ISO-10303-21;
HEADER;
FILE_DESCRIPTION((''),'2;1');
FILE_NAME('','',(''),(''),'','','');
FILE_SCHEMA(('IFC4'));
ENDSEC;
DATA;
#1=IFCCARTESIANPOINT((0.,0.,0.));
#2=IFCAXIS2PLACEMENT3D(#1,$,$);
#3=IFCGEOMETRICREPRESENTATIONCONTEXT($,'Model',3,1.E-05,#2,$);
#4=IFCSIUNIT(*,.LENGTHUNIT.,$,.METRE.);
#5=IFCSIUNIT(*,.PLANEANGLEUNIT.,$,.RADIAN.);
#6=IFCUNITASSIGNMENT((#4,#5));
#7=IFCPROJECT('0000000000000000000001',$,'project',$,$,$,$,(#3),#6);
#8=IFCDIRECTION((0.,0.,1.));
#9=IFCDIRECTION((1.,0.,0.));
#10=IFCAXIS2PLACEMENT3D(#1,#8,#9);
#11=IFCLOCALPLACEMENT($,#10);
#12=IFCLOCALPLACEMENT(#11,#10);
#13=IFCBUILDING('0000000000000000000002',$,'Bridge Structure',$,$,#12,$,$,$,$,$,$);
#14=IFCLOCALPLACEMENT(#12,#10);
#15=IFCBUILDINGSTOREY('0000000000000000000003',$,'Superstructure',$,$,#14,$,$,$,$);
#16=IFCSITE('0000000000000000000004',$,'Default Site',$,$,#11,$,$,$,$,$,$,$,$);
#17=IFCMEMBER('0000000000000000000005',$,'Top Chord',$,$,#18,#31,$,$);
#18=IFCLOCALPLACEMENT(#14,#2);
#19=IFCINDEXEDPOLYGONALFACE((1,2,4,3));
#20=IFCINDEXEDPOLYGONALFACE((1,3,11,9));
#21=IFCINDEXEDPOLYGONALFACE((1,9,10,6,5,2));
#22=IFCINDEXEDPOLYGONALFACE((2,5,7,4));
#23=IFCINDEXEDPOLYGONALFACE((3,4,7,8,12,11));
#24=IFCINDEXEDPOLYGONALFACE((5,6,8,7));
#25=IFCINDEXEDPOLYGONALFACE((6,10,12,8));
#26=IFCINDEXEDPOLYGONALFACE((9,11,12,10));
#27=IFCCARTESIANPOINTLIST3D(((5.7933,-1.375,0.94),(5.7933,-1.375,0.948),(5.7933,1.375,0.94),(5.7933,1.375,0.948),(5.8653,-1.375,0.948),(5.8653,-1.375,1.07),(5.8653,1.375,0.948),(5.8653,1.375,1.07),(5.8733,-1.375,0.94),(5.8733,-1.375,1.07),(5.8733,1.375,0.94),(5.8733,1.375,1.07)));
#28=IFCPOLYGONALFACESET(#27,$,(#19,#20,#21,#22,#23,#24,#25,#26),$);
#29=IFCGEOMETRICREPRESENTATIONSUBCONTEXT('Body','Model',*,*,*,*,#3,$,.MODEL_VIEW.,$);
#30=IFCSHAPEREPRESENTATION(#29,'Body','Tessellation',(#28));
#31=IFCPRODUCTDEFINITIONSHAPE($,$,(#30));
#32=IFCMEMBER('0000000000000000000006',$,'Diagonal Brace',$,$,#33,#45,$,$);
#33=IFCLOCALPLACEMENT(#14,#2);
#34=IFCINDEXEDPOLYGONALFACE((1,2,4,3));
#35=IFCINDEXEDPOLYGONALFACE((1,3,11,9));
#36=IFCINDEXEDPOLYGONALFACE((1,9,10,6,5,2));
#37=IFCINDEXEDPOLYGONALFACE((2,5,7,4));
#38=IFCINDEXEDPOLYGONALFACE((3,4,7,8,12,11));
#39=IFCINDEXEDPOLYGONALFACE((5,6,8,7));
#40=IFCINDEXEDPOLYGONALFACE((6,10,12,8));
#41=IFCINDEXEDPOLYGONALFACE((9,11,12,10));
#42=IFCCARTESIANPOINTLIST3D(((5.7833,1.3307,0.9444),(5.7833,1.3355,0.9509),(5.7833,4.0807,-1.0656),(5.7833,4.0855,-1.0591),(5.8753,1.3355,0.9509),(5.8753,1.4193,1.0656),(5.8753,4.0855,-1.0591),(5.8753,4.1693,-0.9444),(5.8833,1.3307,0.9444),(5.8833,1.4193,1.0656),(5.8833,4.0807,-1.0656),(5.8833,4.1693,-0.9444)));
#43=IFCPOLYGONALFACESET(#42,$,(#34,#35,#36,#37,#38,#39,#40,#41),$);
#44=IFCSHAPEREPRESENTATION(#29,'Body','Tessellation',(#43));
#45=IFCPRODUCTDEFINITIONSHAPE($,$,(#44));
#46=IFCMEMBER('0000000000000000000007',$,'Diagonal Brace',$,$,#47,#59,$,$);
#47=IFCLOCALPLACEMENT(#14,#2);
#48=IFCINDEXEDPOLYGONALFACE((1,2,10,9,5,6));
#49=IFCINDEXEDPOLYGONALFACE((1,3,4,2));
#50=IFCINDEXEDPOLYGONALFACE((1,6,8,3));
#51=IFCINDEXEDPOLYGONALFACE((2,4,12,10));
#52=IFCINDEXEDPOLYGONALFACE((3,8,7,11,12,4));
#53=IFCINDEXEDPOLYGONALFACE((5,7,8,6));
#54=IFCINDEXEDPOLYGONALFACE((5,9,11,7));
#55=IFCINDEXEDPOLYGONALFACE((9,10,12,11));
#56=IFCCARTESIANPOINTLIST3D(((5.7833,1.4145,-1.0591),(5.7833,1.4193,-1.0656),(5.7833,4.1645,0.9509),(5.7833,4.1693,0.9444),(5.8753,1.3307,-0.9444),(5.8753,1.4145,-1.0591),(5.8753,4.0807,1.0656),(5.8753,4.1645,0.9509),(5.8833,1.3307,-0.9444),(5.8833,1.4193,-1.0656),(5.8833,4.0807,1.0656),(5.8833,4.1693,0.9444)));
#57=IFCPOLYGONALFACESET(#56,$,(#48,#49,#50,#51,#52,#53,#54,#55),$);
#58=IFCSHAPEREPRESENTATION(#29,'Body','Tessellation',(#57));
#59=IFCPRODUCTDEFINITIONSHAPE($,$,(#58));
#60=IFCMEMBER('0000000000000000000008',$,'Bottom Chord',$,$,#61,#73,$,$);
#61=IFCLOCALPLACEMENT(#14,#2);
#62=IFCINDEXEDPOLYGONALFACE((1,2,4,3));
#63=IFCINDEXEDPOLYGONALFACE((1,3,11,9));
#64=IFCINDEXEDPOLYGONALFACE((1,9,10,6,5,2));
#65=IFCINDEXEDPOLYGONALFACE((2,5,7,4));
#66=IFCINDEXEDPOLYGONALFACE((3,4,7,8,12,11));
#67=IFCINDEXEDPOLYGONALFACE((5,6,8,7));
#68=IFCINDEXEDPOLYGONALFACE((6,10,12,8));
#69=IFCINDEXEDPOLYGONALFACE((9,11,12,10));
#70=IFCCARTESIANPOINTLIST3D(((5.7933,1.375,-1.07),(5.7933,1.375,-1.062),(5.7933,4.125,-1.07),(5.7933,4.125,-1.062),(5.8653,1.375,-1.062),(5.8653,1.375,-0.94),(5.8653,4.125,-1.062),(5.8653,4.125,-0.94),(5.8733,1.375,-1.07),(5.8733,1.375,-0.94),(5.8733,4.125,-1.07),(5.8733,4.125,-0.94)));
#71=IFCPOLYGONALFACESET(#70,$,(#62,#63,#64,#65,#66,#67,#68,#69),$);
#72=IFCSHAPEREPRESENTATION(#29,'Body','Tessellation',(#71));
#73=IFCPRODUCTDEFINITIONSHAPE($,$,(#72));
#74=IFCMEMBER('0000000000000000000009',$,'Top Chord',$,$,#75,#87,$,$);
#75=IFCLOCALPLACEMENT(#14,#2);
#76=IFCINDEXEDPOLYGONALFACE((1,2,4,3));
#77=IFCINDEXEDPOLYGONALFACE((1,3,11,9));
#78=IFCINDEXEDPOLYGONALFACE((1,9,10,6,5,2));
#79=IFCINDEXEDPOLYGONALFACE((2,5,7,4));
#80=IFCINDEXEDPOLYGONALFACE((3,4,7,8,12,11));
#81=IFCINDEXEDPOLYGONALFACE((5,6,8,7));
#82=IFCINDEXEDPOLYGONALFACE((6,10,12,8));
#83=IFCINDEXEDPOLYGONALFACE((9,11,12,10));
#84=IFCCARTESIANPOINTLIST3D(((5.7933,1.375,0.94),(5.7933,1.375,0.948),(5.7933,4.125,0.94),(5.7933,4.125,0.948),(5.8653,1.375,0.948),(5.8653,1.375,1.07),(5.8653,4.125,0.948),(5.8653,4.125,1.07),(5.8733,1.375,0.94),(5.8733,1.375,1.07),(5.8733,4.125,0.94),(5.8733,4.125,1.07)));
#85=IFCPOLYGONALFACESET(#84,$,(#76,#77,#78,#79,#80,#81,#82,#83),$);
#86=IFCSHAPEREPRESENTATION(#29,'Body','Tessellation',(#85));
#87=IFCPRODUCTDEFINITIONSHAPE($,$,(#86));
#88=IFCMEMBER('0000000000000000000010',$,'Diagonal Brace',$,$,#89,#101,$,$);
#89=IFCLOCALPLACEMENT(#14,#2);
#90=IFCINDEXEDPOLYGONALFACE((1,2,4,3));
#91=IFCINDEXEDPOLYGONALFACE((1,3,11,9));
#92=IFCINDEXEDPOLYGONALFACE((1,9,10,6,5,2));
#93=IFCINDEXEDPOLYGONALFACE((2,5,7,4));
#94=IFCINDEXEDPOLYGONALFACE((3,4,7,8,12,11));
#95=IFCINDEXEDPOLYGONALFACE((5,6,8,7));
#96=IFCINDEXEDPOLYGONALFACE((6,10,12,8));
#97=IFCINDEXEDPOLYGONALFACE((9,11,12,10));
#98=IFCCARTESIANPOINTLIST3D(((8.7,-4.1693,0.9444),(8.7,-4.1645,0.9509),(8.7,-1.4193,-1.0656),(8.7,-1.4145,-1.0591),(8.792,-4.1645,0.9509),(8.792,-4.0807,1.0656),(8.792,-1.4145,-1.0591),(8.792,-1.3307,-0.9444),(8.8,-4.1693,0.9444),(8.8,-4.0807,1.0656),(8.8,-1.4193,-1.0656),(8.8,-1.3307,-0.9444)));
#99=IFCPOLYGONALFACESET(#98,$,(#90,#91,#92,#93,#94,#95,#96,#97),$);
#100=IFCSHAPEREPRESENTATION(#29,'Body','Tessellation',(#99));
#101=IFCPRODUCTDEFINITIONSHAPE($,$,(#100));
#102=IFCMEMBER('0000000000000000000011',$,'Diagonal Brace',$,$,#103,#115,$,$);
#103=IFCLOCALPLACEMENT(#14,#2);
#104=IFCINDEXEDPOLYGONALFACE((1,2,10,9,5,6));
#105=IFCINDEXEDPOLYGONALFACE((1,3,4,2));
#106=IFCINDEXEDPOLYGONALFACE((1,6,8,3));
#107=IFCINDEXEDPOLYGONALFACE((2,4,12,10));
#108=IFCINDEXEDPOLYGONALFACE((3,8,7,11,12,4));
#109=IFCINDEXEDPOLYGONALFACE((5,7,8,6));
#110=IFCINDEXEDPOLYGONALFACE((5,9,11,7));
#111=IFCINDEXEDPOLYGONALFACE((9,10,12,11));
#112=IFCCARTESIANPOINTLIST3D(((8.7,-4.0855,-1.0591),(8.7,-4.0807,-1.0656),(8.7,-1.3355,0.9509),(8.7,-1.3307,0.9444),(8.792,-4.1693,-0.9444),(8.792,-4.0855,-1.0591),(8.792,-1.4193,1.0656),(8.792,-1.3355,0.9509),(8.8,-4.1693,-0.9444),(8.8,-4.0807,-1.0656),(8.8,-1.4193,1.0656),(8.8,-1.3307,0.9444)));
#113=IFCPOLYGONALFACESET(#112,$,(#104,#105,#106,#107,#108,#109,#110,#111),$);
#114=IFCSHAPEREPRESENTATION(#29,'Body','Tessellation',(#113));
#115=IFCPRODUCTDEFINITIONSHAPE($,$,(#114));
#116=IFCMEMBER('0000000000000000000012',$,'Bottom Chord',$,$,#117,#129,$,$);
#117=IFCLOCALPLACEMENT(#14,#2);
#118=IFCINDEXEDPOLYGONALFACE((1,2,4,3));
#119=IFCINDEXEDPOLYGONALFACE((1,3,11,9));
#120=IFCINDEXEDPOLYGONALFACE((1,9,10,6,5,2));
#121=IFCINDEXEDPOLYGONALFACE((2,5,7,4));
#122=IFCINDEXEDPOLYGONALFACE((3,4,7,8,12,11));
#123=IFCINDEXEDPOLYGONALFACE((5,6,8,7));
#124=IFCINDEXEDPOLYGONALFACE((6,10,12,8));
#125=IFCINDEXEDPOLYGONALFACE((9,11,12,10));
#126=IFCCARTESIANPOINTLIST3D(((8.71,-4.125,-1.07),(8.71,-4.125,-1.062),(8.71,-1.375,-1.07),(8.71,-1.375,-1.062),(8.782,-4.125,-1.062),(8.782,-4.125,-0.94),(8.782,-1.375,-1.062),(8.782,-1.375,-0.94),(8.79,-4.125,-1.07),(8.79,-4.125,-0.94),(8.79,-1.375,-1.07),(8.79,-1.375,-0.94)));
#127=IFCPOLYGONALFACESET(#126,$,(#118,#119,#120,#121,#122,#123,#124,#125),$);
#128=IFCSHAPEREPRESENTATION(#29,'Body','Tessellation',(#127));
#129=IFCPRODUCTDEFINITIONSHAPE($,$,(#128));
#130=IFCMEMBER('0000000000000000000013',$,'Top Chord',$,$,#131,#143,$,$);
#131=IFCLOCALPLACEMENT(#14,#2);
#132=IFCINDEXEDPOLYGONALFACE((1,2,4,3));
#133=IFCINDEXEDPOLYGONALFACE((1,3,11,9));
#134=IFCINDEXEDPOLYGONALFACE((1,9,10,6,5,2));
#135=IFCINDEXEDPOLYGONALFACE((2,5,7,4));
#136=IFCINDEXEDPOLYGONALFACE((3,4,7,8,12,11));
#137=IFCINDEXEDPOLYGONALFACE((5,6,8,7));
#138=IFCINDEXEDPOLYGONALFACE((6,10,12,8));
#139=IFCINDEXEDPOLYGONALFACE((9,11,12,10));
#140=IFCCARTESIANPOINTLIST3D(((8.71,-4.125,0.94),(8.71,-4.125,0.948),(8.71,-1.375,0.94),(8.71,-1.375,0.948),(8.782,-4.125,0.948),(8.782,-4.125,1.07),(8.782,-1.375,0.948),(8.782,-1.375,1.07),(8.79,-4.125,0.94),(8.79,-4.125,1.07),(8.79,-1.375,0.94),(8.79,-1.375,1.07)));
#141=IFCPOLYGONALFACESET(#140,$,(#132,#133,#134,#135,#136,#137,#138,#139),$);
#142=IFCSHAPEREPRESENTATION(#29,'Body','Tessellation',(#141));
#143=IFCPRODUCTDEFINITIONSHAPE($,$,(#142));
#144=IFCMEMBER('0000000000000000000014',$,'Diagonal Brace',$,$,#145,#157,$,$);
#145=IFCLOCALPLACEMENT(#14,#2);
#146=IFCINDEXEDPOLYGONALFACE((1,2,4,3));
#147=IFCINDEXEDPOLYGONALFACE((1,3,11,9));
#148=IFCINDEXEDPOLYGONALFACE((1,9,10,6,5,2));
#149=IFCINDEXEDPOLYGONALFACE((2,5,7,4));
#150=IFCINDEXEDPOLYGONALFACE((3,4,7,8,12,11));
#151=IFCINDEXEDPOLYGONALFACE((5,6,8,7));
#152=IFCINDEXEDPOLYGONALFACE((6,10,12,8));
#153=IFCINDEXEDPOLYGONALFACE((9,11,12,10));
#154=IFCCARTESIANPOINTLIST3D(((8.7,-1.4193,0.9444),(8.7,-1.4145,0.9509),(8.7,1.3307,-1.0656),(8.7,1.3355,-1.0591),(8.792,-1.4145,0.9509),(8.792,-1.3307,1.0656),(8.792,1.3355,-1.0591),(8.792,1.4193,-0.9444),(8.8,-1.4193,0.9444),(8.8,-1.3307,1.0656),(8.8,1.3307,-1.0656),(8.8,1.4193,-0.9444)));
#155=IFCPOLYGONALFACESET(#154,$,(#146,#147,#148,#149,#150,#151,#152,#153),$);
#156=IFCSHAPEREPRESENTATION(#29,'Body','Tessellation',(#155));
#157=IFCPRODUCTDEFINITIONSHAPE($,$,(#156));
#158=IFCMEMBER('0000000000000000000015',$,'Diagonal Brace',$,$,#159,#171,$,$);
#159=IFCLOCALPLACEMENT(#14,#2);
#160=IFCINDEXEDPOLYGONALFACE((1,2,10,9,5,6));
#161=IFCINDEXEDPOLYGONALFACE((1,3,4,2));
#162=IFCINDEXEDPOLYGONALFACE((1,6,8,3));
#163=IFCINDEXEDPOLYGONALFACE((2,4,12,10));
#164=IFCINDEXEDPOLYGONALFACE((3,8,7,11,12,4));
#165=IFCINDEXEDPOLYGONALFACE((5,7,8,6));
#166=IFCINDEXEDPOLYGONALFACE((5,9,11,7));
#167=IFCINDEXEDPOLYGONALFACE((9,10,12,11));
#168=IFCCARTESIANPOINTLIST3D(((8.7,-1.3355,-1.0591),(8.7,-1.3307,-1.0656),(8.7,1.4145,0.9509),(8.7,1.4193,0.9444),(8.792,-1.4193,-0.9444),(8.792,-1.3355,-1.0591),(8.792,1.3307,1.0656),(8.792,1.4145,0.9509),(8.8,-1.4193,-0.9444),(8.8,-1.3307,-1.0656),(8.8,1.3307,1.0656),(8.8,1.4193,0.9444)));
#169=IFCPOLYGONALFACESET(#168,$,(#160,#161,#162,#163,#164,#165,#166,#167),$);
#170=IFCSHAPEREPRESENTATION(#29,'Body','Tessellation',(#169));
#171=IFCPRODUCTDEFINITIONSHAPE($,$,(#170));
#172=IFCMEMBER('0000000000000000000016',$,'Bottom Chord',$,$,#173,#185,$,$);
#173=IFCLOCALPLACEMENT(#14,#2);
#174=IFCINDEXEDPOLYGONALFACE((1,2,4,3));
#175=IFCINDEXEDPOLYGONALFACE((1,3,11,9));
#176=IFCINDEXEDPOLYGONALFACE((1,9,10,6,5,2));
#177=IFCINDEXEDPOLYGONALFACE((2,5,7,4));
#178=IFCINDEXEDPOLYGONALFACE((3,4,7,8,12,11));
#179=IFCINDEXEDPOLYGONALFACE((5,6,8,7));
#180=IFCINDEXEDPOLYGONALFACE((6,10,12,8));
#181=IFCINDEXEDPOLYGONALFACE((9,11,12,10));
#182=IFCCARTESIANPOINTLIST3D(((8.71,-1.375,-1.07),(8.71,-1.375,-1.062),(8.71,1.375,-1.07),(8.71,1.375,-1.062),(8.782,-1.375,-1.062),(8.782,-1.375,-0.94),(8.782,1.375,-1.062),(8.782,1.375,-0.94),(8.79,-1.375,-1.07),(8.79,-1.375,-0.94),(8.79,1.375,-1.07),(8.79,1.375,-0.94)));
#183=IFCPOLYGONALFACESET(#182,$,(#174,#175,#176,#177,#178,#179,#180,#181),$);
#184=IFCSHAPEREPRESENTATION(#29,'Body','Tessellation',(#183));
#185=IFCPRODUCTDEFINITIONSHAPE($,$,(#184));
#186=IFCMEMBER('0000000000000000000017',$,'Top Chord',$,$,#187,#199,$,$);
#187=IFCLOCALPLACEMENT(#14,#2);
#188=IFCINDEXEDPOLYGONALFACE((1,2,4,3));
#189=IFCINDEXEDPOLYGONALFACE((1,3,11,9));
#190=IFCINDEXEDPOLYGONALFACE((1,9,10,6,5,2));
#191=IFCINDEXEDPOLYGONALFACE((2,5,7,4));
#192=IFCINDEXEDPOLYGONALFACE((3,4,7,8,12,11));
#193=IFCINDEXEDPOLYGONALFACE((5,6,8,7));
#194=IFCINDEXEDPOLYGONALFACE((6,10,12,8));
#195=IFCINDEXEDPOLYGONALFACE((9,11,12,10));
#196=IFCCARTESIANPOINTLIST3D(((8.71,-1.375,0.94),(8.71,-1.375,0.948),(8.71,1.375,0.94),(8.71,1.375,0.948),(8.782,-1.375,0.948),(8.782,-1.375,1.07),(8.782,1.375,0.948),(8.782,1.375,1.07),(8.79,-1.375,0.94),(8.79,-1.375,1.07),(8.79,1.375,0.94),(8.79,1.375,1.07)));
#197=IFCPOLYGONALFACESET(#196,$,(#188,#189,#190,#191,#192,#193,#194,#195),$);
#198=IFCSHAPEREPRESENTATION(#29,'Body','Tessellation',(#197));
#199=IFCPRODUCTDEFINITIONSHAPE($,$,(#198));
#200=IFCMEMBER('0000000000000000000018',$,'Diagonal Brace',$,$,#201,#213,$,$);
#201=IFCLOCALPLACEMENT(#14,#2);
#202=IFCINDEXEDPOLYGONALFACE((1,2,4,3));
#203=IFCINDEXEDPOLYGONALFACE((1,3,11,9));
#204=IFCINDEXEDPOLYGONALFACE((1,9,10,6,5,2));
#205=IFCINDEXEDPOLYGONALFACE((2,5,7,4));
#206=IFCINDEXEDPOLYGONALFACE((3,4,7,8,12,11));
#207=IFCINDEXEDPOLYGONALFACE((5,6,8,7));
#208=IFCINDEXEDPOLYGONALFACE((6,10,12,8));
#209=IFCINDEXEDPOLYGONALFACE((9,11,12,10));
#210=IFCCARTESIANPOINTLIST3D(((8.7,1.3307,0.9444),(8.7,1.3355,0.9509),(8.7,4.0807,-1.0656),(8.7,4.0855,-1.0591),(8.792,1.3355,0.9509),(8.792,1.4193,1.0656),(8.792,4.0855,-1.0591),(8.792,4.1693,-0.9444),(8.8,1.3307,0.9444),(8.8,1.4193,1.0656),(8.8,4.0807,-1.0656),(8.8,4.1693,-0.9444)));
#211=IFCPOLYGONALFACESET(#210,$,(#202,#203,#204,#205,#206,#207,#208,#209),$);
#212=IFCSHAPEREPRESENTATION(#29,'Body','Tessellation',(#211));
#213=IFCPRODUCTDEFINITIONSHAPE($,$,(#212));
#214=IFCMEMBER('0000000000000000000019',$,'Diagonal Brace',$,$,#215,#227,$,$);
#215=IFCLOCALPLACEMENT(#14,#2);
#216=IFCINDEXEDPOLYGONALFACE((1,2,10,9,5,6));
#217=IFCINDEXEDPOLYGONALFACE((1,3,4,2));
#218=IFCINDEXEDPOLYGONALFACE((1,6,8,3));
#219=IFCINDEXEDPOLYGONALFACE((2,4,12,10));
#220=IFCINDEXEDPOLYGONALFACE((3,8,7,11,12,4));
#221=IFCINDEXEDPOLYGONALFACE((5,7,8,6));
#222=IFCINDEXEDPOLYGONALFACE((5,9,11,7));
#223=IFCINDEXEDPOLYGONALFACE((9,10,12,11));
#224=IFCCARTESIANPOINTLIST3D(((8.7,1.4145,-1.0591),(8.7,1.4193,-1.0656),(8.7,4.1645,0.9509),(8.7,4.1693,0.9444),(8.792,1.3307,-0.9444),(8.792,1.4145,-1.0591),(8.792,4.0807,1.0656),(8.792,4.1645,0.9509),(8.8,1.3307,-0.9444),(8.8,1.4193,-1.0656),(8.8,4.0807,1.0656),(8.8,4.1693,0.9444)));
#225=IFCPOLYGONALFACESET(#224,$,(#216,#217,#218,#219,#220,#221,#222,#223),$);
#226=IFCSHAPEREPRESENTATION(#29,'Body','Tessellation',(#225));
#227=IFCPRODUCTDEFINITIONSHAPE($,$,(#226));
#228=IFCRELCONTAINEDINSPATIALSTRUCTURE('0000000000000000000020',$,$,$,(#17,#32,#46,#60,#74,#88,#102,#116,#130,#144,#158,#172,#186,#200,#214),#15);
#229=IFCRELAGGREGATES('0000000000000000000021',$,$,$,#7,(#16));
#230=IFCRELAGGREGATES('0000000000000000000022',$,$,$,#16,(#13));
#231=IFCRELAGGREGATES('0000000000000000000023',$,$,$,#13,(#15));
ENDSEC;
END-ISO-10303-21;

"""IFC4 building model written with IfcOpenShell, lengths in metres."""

from ifc_helpers import new_model, si_unit, frame, origin, origin_with_axes, origin_2d_with_axis, place, context, subcontext, project, spatial, l_section, extrude, element, save


model = new_model("IFC4")

# Units and contexts
model_context = context("Model", 3, precision=1e-05, world=origin())
body_context = subcontext(model_context, "Body", "Model", "MODEL_VIEW")
ifc_project = project(units=[si_unit("LENGTHUNIT", "METRE"), si_unit("PLANEANGLEUNIT", "RADIAN")], contexts=[model_context])

# Site, building, storey
site_placement = place(None, origin_with_axes())
site = spatial("IfcSite", under=ifc_project, at=site_placement, Name="Default Site")
building_placement = place(site_placement, origin_with_axes())
building = spatial("IfcBuilding", under=site, at=building_placement, Name="Bridge Structure")
storey_placement = place(building_placement, origin_with_axes())
storey = spatial("IfcBuildingStorey", under=building, at=storey_placement, Name="Superstructure")

# Members
member_1_placement = place(storey_placement, frame((5.8333, -1.375, 1.005), z_axis=(0.0, 1.0, 0.0), x_axis=(-1.0, 0.0, 0.0)))
element("IfcMember", 1, at=member_1_placement, inside=storey, Name="Top Chord", context=body_context, shape_type="SweptSolid", body=[
    extrude(l_section(Depth=0.13, Width=0.08, Thickness=0.008, at=origin_2d_with_axis()), origin_with_axes(), (0.0, 0.0, 1.0), 2.75),
])
for number, where, z_axis, x_axis, name in (
    (2, (5.8333, 1.375, 1.005), (0.0, 0.807337, -0.59009), (-1.0, 0.0, 0.0), "Diagonal Brace"),
    (3, (5.8333, 1.375, -1.005), (0.0, 0.807337, 0.59009), (-1.0, 0.0, 0.0), "Diagonal Brace"),
):
    element("IfcMember", number, at=place(storey_placement, frame(where, z_axis=z_axis, x_axis=x_axis)), inside=storey, Name=name, context=body_context, shape_type="SweptSolid", body=[
        extrude(l_section(Depth=0.15, Width=0.1, Thickness=0.008, at=origin_2d_with_axis()), origin_with_axes(), (0.0, 0.0, 1.0), 3.4063),
    ])
for number, where, z_axis, x_axis, name in (
    (4, (5.8333, 1.375, -1.005), (0.0, 1.0, 0.0), (-1.0, 0.0, 0.0), "Bottom Chord"),
    (5, (5.8333, 1.375, 1.005), (0.0, 1.0, 0.0), (-1.0, 0.0, 0.0), "Top Chord"),
):
    element("IfcMember", number, at=place(storey_placement, frame(where, z_axis=z_axis, x_axis=x_axis)), inside=storey, Name=name, context=body_context, shape_type="SweptSolid", body=[
        extrude(l_section(Depth=0.13, Width=0.08, Thickness=0.008, at=origin_2d_with_axis()), origin_with_axes(), (0.0, 0.0, 1.0), 2.75),
    ])
for number, where, z_axis, x_axis, name in (
    (6, (8.75, -4.125, 1.005), (0.0, 0.807337, -0.59009), (-1.0, 0.0, 0.0), "Diagonal Brace"),
    (7, (8.75, -4.125, -1.005), (0.0, 0.807337, 0.59009), (-1.0, 0.0, 0.0), "Diagonal Brace"),
):
    element("IfcMember", number, at=place(storey_placement, frame(where, z_axis=z_axis, x_axis=x_axis)), inside=storey, Name=name, context=body_context, shape_type="SweptSolid", body=[
        extrude(l_section(Depth=0.15, Width=0.1, Thickness=0.008, at=origin_2d_with_axis()), origin_with_axes(), (0.0, 0.0, 1.0), 3.4063),
    ])
for number, where, z_axis, x_axis, name in (
    (8, (8.75, -4.125, -1.005), (0.0, 1.0, 0.0), (-1.0, 0.0, 0.0), "Bottom Chord"),
    (9, (8.75, -4.125, 1.005), (0.0, 1.0, 0.0), (-1.0, 0.0, 0.0), "Top Chord"),
):
    element("IfcMember", number, at=place(storey_placement, frame(where, z_axis=z_axis, x_axis=x_axis)), inside=storey, Name=name, context=body_context, shape_type="SweptSolid", body=[
        extrude(l_section(Depth=0.13, Width=0.08, Thickness=0.008, at=origin_2d_with_axis()), origin_with_axes(), (0.0, 0.0, 1.0), 2.75),
    ])
for number, where, z_axis, x_axis, name in (
    (10, (8.75, -1.375, 1.005), (0.0, 0.807337, -0.59009), (-1.0, 0.0, 0.0), "Diagonal Brace"),
    (11, (8.75, -1.375, -1.005), (0.0, 0.807337, 0.59009), (-1.0, 0.0, 0.0), "Diagonal Brace"),
):
    element("IfcMember", number, at=place(storey_placement, frame(where, z_axis=z_axis, x_axis=x_axis)), inside=storey, Name=name, context=body_context, shape_type="SweptSolid", body=[
        extrude(l_section(Depth=0.15, Width=0.1, Thickness=0.008, at=origin_2d_with_axis()), origin_with_axes(), (0.0, 0.0, 1.0), 3.4063),
    ])
for number, where, z_axis, x_axis, name in (
    (12, (8.75, -1.375, -1.005), (0.0, 1.0, 0.0), (-1.0, 0.0, 0.0), "Bottom Chord"),
    (13, (8.75, -1.375, 1.005), (0.0, 1.0, 0.0), (-1.0, 0.0, 0.0), "Top Chord"),
):
    element("IfcMember", number, at=place(storey_placement, frame(where, z_axis=z_axis, x_axis=x_axis)), inside=storey, Name=name, context=body_context, shape_type="SweptSolid", body=[
        extrude(l_section(Depth=0.13, Width=0.08, Thickness=0.008, at=origin_2d_with_axis()), origin_with_axes(), (0.0, 0.0, 1.0), 2.75),
    ])
for number, where, z_axis, x_axis, name in (
    (14, (8.75, 1.375, 1.005), (0.0, 0.807337, -0.59009), (-1.0, 0.0, 0.0), "Diagonal Brace"),
    (15, (8.75, 1.375, -1.005), (0.0, 0.807337, 0.59009), (-1.0, 0.0, 0.0), "Diagonal Brace"),
):
    element("IfcMember", number, at=place(storey_placement, frame(where, z_axis=z_axis, x_axis=x_axis)), inside=storey, Name=name, context=body_context, shape_type="SweptSolid", body=[
        extrude(l_section(Depth=0.15, Width=0.1, Thickness=0.008, at=origin_2d_with_axis()), origin_with_axes(), (0.0, 0.0, 1.0), 3.4063),
    ])

save(model, "model.ifc")
